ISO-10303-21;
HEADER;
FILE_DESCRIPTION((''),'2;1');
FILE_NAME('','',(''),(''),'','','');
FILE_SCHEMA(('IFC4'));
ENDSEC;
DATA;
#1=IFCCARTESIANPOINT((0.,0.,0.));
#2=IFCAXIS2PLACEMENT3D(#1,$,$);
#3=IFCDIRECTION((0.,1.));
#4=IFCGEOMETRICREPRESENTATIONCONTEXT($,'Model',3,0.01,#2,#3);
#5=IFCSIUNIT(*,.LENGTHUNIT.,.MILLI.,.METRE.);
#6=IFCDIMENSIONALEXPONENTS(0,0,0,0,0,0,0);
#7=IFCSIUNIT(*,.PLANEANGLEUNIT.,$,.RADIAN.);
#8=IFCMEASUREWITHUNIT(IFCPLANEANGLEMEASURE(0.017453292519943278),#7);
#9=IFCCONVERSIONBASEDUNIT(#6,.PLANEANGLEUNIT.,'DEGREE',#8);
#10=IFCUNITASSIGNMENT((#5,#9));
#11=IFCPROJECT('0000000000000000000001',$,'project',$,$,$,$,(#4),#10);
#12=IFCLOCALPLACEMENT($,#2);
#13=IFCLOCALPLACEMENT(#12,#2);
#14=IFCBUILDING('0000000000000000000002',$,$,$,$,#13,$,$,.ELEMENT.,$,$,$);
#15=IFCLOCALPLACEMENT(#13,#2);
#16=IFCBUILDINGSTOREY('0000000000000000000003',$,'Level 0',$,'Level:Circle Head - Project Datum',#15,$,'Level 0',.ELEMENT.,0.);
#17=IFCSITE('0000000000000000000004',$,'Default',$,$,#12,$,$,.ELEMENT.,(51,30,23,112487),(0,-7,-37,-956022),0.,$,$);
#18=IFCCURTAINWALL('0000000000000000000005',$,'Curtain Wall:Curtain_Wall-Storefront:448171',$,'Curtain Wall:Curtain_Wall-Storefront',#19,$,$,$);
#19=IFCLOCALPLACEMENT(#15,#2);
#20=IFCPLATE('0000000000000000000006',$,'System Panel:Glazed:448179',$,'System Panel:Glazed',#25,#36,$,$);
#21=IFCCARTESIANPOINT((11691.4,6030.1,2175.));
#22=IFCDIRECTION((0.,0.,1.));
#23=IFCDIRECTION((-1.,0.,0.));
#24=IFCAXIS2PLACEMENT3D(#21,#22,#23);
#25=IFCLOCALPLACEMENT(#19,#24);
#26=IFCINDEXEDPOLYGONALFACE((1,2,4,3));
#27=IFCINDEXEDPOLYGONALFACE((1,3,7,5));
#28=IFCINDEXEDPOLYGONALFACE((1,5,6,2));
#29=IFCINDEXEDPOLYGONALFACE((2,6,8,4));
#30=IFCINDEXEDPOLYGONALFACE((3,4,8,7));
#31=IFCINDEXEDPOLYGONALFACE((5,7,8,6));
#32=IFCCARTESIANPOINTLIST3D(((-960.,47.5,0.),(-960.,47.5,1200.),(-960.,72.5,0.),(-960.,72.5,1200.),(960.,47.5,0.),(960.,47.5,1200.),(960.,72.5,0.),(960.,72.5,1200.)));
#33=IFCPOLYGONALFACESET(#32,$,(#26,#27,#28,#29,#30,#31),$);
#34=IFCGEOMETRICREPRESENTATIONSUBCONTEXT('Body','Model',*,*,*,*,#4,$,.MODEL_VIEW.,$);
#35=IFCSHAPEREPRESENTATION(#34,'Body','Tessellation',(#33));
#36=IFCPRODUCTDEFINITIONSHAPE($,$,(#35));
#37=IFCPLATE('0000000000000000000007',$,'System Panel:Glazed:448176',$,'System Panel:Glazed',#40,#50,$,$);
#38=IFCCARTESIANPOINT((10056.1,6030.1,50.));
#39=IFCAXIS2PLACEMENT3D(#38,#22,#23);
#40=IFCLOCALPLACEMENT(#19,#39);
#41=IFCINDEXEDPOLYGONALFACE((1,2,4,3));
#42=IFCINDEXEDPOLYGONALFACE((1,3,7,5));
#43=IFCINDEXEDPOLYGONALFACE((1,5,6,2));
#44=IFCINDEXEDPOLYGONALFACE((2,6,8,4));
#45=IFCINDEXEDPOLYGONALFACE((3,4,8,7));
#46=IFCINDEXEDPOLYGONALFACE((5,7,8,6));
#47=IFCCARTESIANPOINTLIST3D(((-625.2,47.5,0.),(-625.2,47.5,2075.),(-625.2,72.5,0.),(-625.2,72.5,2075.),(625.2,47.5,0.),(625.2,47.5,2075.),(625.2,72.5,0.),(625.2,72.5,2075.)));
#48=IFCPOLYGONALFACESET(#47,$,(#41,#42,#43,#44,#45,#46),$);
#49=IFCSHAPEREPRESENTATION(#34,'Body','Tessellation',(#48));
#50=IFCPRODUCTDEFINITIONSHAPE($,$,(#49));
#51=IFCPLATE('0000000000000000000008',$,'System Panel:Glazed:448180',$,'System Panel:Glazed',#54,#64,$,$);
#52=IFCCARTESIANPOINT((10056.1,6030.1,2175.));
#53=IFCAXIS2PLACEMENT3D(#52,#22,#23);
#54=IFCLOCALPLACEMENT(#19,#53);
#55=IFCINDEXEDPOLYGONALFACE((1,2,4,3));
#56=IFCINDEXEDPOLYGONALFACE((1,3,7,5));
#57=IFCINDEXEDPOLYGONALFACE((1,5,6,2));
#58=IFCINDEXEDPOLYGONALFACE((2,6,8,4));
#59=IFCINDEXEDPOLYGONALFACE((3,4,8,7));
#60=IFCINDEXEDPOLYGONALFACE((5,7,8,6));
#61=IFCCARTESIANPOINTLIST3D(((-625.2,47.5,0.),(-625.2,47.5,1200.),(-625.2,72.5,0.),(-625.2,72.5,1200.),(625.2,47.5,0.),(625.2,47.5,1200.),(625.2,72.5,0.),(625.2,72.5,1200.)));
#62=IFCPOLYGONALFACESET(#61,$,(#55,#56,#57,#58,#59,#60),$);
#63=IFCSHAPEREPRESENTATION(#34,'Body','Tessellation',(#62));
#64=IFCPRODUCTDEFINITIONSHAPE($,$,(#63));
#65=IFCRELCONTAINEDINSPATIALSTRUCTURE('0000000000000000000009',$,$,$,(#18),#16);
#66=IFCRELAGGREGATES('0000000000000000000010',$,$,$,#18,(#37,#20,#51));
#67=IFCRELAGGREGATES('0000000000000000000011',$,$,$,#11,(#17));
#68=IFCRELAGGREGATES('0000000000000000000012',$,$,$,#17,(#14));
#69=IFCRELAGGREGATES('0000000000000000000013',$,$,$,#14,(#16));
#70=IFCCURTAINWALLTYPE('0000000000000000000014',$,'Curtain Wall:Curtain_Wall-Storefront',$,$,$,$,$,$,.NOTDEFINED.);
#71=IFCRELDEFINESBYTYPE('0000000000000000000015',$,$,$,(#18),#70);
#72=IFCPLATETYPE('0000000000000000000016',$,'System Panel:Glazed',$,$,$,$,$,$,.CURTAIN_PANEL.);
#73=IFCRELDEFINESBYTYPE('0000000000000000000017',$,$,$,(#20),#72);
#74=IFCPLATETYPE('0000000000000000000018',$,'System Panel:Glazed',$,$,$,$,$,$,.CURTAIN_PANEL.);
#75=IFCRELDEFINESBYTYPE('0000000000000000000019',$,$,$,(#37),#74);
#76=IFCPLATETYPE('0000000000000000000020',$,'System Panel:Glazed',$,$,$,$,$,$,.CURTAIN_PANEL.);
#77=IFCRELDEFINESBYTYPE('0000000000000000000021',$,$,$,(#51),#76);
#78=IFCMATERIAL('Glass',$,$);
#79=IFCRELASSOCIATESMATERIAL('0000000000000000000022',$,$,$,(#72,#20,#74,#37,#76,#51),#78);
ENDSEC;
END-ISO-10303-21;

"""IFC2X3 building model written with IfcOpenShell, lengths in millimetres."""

from ifc_helpers import new_model, entity, si_unit, converted_unit, direction, frame, origin, origin_2d_with_axis, place, context, subcontext, project, spatial, rectangle, extrude, source, transform, mapped, material, type_object, type_shapes, element, aggregate, save


model = new_model("IFC2X3")

# Units and contexts
model_context = context("Model", 3, precision=0.01, world=origin(), true_north=direction((0.0, 1.0)))
body_context = subcontext(model_context, "Body", "Model", "MODEL_VIEW")
ifc_project = project(units=[si_unit("LENGTHUNIT", "METRE", prefix="MILLI"), converted_unit("PLANEANGLEUNIT", "DEGREE", entity("IfcPlaneAngleMeasure", 0.017453292519943278), si_unit("PLANEANGLEUNIT", "RADIAN"), dimensions=[0, 0, 0, 0, 0, 0, 0])], contexts=[model_context])

# Site, building, storey
site_placement = place(None, origin())
site = spatial("IfcSite", under=ifc_project, at=site_placement, Name="Default", CompositionType="ELEMENT", RefLatitude=(51, 30, 23, 112487), RefLongitude=(0, -7, -37, -956022), RefElevation=0.0)
building_placement = place(site_placement, origin())
building = spatial("IfcBuilding", under=site, at=building_placement, CompositionType="ELEMENT")
storey_placement = place(building_placement, origin())
storey = spatial("IfcBuildingStorey", under=building, at=storey_placement, Name="Level 0", ObjectType="Level:Circle Head - Project Datum", LongName="Level 0", CompositionType="ELEMENT", Elevation=0.0)

# Curtain wall
curtain_wall_type = type_object("IfcCurtainWallType", Name="Curtain Wall:Curtain_Wall-Storefront", PredefinedType="NOTDEFINED")
curtain_wall_1_placement = place(storey_placement, origin())
curtain_wall_1 = element("IfcCurtainWall", 1, at=curtain_wall_1_placement, inside=storey, type_object=curtain_wall_type, Name="Curtain Wall:Curtain_Wall-Storefront:448171", ObjectType="Curtain Wall:Curtain_Wall-Storefront")

# Plates
ifc_material_1 = material(Name="Glass")
plate_type_1 = type_object("IfcPlateType", Name="System Panel:Glazed", PredefinedType="CURTAIN_PANEL", material=ifc_material_1)
shared_shape_1 = source(origin(), body_context, "Body", "SweptSolid", [
    extrude(rectangle(XDim=25.0, YDim=1920.0, at=origin_2d_with_axis()), frame((0.0, 60.0, 0.0), z_axis=(0.0, 0.0, 1.0), x_axis=(0.0, 1.0, 0.0)), (0.0, 0.0, 1.0), 1200.0),
])
type_shapes(plate_type_1, [shared_shape_1])
plate_1_placement = place(curtain_wall_1_placement, frame((11691.4, 6030.1, 2175.0), z_axis=(0.0, 0.0, 1.0), x_axis=(-1.0, 0.0, 0.0)))
plate_1 = element("IfcPlate", 2, at=plate_1_placement, type_object=plate_type_1, material=ifc_material_1, Name="System Panel:Glazed:448179", ObjectType="System Panel:Glazed", context=body_context, shape_type="MappedRepresentation", body=[
    mapped(shared_shape_1, transform((0.0, 0.0, 0.0), scale=1.0)),
])
plate_type_2 = type_object("IfcPlateType", Name="System Panel:Glazed", PredefinedType="CURTAIN_PANEL", material=ifc_material_1)
shared_shape_2 = source(origin(), body_context, "Body", "SweptSolid", [
    extrude(rectangle(XDim=25.0, YDim=1250.5, at=origin_2d_with_axis()), frame((0.0, 60.0, 0.0), z_axis=(0.0, 0.0, 1.0), x_axis=(0.0, 1.0, 0.0)), (0.0, 0.0, 1.0), 2075.0),
])
type_shapes(plate_type_2, [shared_shape_2])
plate_2_placement = place(curtain_wall_1_placement, frame((10056.1, 6030.1, 50.0), z_axis=(0.0, 0.0, 1.0), x_axis=(-1.0, 0.0, 0.0)))
plate_2 = element("IfcPlate", 3, at=plate_2_placement, type_object=plate_type_2, material=ifc_material_1, Name="System Panel:Glazed:448176", ObjectType="System Panel:Glazed", context=body_context, shape_type="MappedRepresentation", body=[
    mapped(shared_shape_2, transform((0.0, 0.0, 0.0), scale=1.0)),
])
plate_type_3 = type_object("IfcPlateType", Name="System Panel:Glazed", PredefinedType="CURTAIN_PANEL", material=ifc_material_1)
shared_shape_3 = source(origin(), body_context, "Body", "SweptSolid", [
    extrude(rectangle(XDim=25.0, YDim=1250.5, at=origin_2d_with_axis()), frame((0.0, 60.0, 0.0), z_axis=(0.0, 0.0, 1.0), x_axis=(0.0, 1.0, 0.0)), (0.0, 0.0, 1.0), 1200.0),
])
type_shapes(plate_type_3, [shared_shape_3])
plate_3_placement = place(curtain_wall_1_placement, frame((10056.1, 6030.1, 2175.0), z_axis=(0.0, 0.0, 1.0), x_axis=(-1.0, 0.0, 0.0)))
plate_3 = element("IfcPlate", 4, at=plate_3_placement, type_object=plate_type_3, material=ifc_material_1, Name="System Panel:Glazed:448180", ObjectType="System Panel:Glazed", context=body_context, shape_type="MappedRepresentation", body=[
    mapped(shared_shape_3, transform((0.0, 0.0, 0.0), scale=1.0)),
])
aggregate(curtain_wall_1, [plate_2, plate_1, plate_3])

save(model, "model.ifc")
